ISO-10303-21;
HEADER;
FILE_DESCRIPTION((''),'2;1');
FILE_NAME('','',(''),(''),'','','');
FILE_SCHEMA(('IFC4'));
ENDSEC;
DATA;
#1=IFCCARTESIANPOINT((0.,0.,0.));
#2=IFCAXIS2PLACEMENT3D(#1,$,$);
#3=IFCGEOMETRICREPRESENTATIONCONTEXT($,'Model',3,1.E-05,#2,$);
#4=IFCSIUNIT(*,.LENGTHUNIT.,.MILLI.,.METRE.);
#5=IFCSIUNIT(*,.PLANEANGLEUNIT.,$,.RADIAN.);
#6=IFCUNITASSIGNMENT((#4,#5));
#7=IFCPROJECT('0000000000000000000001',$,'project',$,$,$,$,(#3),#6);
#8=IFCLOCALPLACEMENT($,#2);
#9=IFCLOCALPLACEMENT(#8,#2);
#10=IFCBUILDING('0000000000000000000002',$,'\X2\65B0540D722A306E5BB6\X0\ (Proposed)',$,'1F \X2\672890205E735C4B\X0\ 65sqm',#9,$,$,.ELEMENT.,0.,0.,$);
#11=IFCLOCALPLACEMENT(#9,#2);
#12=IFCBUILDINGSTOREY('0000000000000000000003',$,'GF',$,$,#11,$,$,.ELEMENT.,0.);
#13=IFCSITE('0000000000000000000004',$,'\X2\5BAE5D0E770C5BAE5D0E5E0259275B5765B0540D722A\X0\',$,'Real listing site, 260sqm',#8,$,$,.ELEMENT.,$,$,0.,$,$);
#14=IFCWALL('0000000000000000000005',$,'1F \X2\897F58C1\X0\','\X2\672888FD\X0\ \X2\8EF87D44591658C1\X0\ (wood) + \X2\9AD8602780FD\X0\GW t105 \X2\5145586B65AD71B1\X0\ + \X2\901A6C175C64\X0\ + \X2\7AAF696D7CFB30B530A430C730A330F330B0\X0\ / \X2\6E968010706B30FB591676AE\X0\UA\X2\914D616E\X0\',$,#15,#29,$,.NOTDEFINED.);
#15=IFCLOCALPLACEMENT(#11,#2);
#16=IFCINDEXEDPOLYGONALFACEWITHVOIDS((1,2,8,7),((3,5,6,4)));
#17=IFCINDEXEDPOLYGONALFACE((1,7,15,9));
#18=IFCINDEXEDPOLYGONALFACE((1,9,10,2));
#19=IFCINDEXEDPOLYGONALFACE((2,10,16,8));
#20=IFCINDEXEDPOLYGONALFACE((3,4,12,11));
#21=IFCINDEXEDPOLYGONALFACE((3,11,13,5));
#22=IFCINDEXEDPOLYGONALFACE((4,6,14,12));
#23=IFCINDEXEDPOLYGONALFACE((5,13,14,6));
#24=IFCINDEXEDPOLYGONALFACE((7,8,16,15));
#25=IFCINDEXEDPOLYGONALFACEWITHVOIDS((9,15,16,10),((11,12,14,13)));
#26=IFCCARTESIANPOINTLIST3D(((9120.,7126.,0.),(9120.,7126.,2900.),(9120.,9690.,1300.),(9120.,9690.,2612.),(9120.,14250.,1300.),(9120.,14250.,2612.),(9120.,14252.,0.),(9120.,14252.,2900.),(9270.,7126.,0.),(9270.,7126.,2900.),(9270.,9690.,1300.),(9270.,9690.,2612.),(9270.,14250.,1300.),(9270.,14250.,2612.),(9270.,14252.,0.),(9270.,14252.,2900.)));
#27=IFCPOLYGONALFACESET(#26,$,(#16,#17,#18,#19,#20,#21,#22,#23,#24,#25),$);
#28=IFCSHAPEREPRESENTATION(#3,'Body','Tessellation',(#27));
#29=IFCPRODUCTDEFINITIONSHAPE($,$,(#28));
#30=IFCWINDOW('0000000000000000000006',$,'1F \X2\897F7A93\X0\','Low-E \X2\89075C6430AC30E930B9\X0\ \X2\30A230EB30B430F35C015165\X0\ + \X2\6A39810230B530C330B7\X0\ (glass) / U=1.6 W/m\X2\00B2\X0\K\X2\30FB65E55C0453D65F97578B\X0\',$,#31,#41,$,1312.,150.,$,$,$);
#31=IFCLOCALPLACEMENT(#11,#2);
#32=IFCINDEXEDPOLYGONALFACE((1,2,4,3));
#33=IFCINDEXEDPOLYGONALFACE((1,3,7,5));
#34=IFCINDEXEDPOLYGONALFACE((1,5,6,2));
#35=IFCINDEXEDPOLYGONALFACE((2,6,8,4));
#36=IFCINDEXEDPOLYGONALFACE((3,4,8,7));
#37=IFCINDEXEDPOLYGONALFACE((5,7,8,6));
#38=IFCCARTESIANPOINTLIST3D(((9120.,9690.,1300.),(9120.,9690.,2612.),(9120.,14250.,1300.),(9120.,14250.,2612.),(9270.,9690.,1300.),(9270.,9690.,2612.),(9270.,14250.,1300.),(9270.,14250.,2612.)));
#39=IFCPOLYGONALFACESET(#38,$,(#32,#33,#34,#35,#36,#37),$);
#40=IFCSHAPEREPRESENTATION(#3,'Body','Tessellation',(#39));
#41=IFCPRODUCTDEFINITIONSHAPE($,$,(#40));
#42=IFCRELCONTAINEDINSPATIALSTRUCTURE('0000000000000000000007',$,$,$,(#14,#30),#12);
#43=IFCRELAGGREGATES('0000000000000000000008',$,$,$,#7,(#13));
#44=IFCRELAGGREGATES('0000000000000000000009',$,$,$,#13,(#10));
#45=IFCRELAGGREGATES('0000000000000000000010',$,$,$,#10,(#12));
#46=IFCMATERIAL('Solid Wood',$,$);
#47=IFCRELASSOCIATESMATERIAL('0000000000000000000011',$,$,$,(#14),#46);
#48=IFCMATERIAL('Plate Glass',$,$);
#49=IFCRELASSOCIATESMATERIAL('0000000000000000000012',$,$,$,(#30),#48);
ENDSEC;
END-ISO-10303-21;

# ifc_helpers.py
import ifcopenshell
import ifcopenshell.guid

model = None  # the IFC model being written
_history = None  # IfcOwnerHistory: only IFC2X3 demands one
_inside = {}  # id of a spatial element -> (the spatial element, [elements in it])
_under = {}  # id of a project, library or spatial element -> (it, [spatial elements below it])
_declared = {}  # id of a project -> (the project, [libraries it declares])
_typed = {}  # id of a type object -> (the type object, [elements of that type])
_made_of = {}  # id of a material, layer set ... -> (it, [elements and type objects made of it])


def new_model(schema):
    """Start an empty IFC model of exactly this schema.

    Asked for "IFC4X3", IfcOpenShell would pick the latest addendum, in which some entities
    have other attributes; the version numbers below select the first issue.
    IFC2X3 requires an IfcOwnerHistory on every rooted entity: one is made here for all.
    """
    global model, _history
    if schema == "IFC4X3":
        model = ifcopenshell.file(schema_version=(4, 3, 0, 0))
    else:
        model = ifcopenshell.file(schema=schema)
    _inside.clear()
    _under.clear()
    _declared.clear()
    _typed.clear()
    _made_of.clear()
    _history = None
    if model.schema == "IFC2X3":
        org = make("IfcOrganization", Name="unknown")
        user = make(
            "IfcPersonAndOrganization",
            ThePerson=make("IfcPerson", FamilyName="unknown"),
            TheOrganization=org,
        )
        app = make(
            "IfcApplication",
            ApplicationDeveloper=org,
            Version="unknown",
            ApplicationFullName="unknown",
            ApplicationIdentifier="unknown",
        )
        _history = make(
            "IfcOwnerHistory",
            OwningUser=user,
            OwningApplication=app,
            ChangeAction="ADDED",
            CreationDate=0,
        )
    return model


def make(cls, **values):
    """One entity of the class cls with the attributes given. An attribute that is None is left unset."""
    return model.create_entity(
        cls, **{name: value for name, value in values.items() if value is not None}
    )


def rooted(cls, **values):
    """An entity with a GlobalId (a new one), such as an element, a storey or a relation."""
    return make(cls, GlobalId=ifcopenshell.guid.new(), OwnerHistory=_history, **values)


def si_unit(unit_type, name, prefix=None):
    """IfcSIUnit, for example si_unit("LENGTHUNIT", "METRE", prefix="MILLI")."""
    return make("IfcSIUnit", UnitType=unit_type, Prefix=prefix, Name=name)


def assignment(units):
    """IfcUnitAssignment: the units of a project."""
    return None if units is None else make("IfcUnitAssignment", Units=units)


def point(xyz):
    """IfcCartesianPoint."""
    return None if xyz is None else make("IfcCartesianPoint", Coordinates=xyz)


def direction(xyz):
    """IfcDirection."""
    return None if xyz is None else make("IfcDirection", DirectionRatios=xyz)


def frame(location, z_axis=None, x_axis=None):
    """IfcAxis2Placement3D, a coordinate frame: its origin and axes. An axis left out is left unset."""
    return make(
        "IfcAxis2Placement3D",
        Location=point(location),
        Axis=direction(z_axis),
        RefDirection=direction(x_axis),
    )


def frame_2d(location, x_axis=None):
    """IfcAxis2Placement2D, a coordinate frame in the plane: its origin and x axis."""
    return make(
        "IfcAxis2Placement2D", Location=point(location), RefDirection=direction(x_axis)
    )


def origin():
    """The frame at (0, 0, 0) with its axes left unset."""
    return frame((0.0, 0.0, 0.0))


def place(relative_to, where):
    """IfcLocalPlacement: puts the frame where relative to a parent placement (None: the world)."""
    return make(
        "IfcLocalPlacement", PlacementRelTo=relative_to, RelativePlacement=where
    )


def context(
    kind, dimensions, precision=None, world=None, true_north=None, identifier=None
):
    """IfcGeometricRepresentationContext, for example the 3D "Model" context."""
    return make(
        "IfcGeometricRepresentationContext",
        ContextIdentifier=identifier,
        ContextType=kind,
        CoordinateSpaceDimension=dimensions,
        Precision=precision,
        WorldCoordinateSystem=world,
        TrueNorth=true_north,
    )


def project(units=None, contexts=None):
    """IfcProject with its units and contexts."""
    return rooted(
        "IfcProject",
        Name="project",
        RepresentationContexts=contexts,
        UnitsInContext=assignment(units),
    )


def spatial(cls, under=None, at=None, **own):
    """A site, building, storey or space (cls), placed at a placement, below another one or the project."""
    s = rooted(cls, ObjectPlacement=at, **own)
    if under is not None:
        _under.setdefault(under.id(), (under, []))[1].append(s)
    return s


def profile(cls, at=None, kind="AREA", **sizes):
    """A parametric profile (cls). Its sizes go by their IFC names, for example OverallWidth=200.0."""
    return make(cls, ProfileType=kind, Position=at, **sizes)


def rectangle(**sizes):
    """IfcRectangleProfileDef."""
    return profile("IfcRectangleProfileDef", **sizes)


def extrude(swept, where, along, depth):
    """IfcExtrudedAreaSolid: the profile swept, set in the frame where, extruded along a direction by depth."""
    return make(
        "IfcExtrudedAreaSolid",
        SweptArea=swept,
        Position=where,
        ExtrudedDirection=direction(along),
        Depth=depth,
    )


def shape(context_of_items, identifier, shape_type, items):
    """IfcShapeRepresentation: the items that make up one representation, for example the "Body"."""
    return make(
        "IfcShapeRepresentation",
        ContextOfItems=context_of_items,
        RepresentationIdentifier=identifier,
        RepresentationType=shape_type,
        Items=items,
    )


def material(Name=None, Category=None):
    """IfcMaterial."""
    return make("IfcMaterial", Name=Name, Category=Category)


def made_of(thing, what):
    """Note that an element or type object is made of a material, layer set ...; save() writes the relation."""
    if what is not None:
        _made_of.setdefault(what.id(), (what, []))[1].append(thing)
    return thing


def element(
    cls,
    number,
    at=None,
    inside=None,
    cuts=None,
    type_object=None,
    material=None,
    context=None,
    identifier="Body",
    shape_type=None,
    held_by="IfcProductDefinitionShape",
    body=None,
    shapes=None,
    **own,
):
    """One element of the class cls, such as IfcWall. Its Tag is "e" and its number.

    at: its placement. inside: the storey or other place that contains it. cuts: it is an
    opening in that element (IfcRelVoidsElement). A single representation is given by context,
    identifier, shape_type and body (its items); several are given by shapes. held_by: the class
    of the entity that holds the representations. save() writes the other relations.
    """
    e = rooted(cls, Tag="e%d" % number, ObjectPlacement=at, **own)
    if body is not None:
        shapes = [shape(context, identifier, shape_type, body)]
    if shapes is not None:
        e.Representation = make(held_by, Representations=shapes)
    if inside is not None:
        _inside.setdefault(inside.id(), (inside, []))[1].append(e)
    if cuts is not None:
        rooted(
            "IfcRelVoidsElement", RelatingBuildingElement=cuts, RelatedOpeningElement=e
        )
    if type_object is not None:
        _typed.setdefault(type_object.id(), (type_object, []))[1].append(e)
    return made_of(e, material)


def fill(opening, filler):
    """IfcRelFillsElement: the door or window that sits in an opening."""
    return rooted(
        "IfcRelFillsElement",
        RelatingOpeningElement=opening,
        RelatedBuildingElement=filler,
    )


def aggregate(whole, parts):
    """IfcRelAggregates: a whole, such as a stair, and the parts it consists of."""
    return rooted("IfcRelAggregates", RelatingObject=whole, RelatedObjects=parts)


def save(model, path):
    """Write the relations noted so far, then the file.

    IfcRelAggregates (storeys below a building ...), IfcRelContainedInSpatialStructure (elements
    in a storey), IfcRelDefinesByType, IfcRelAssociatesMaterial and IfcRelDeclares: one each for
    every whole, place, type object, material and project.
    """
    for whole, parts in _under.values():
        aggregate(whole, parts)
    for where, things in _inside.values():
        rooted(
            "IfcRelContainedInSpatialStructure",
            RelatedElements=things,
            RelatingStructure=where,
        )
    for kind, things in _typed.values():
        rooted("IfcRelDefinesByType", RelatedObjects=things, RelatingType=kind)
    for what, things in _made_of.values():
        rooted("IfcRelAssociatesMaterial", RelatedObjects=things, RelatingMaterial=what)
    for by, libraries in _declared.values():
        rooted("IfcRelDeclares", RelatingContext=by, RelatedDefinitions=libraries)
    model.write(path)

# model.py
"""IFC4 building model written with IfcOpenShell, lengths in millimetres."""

from ifc_helpers import new_model, si_unit, frame, frame_2d, origin, place, context, project, spatial, rectangle, extrude, material, element, fill, save


model = new_model("IFC4")

# Units and contexts
model_context = context("Model", 3, precision=1e-05, world=origin())
ifc_project = project(units=[si_unit("LENGTHUNIT", "METRE", prefix="MILLI"), si_unit("PLANEANGLEUNIT", "RADIAN")], contexts=[model_context])

# Site, building, storey
site_placement = place(None, origin())
site = spatial("IfcSite", under=ifc_project, at=site_placement, Name="宮崎県宮崎市大字新名爪", ObjectType="Real listing site, 260sqm", CompositionType="ELEMENT", RefElevation=0.0)
building_placement = place(site_placement, origin())
building = spatial("IfcBuilding", under=site, at=building_placement, Name="新名爪の家 (Proposed)", ObjectType="1F 木造平屋 65sqm", CompositionType="ELEMENT", ElevationOfRefHeight=0.0, ElevationOfTerrain=0.0)
storey_placement = place(building_placement, origin())
storey = spatial("IfcBuildingStorey", under=building, at=storey_placement, Name="GF", CompositionType="ELEMENT", Elevation=0.0)

# Shared definitions
ifc_material_1 = material(Name="Solid Wood")

# Shared definitions
ifc_material_2 = material(Name="Plate Glass")

# Wall, opening, window
wall_1_placement = place(storey_placement, frame((4560.0, 3563.0, 0.0)))
wall_1 = element("IfcWall", 1, at=wall_1_placement, inside=storey, material=ifc_material_1, Name="1F 西壁", Description="木製 軸組外壁 (wood) + 高性能GW t105 充填断熱 + 通気層 + 窯業系サイディング / 準耐火・外皮UA配慮", PredefinedType="NOTDEFINED", context=model_context, shape_type="SweptSolid", body=[
    extrude(rectangle(XDim=150.0, YDim=7126.0, at=frame_2d((75.0, 3563.0))), frame((4560.0, 3563.0, 0.0)), (0.0, 0.0, 1.0), 2900.0),
])
opening_1_placement = place(storey_placement, frame((4560.0, 4845.0, 650.0)))
opening_1 = element("IfcOpeningElement", 2, at=opening_1_placement, cuts=wall_1, PredefinedType="NOTDEFINED", context=model_context, shape_type="SweptSolid", body=[
    extrude(rectangle(XDim=150.0, YDim=4560.0, at=frame_2d((75.0, 2280.0))), frame((4560.0, 4845.0, 650.0)), (0.0, 0.0, 1.0), 1312.0),
])
window_1_placement = place(storey_placement, frame((4560.0, 4845.0, 650.0)))
window_1 = element("IfcWindow", 3, at=window_1_placement, inside=storey, material=ifc_material_2, Name="1F 西窓", Description="Low-E 複層ガラス アルゴン封入 + 樹脂サッシ (glass) / U=1.6 W/m²K・日射取得型", OverallHeight=1312.0, OverallWidth=150.0, context=model_context, shape_type="SweptSolid", body=[
    extrude(rectangle(XDim=150.0, YDim=4560.0, at=frame_2d((75.0, 2280.0))), frame((4560.0, 4845.0, 650.0)), (0.0, 0.0, 1.0), 1312.0),
])
fill(opening_1, window_1)

save(model, "model.ifc")
